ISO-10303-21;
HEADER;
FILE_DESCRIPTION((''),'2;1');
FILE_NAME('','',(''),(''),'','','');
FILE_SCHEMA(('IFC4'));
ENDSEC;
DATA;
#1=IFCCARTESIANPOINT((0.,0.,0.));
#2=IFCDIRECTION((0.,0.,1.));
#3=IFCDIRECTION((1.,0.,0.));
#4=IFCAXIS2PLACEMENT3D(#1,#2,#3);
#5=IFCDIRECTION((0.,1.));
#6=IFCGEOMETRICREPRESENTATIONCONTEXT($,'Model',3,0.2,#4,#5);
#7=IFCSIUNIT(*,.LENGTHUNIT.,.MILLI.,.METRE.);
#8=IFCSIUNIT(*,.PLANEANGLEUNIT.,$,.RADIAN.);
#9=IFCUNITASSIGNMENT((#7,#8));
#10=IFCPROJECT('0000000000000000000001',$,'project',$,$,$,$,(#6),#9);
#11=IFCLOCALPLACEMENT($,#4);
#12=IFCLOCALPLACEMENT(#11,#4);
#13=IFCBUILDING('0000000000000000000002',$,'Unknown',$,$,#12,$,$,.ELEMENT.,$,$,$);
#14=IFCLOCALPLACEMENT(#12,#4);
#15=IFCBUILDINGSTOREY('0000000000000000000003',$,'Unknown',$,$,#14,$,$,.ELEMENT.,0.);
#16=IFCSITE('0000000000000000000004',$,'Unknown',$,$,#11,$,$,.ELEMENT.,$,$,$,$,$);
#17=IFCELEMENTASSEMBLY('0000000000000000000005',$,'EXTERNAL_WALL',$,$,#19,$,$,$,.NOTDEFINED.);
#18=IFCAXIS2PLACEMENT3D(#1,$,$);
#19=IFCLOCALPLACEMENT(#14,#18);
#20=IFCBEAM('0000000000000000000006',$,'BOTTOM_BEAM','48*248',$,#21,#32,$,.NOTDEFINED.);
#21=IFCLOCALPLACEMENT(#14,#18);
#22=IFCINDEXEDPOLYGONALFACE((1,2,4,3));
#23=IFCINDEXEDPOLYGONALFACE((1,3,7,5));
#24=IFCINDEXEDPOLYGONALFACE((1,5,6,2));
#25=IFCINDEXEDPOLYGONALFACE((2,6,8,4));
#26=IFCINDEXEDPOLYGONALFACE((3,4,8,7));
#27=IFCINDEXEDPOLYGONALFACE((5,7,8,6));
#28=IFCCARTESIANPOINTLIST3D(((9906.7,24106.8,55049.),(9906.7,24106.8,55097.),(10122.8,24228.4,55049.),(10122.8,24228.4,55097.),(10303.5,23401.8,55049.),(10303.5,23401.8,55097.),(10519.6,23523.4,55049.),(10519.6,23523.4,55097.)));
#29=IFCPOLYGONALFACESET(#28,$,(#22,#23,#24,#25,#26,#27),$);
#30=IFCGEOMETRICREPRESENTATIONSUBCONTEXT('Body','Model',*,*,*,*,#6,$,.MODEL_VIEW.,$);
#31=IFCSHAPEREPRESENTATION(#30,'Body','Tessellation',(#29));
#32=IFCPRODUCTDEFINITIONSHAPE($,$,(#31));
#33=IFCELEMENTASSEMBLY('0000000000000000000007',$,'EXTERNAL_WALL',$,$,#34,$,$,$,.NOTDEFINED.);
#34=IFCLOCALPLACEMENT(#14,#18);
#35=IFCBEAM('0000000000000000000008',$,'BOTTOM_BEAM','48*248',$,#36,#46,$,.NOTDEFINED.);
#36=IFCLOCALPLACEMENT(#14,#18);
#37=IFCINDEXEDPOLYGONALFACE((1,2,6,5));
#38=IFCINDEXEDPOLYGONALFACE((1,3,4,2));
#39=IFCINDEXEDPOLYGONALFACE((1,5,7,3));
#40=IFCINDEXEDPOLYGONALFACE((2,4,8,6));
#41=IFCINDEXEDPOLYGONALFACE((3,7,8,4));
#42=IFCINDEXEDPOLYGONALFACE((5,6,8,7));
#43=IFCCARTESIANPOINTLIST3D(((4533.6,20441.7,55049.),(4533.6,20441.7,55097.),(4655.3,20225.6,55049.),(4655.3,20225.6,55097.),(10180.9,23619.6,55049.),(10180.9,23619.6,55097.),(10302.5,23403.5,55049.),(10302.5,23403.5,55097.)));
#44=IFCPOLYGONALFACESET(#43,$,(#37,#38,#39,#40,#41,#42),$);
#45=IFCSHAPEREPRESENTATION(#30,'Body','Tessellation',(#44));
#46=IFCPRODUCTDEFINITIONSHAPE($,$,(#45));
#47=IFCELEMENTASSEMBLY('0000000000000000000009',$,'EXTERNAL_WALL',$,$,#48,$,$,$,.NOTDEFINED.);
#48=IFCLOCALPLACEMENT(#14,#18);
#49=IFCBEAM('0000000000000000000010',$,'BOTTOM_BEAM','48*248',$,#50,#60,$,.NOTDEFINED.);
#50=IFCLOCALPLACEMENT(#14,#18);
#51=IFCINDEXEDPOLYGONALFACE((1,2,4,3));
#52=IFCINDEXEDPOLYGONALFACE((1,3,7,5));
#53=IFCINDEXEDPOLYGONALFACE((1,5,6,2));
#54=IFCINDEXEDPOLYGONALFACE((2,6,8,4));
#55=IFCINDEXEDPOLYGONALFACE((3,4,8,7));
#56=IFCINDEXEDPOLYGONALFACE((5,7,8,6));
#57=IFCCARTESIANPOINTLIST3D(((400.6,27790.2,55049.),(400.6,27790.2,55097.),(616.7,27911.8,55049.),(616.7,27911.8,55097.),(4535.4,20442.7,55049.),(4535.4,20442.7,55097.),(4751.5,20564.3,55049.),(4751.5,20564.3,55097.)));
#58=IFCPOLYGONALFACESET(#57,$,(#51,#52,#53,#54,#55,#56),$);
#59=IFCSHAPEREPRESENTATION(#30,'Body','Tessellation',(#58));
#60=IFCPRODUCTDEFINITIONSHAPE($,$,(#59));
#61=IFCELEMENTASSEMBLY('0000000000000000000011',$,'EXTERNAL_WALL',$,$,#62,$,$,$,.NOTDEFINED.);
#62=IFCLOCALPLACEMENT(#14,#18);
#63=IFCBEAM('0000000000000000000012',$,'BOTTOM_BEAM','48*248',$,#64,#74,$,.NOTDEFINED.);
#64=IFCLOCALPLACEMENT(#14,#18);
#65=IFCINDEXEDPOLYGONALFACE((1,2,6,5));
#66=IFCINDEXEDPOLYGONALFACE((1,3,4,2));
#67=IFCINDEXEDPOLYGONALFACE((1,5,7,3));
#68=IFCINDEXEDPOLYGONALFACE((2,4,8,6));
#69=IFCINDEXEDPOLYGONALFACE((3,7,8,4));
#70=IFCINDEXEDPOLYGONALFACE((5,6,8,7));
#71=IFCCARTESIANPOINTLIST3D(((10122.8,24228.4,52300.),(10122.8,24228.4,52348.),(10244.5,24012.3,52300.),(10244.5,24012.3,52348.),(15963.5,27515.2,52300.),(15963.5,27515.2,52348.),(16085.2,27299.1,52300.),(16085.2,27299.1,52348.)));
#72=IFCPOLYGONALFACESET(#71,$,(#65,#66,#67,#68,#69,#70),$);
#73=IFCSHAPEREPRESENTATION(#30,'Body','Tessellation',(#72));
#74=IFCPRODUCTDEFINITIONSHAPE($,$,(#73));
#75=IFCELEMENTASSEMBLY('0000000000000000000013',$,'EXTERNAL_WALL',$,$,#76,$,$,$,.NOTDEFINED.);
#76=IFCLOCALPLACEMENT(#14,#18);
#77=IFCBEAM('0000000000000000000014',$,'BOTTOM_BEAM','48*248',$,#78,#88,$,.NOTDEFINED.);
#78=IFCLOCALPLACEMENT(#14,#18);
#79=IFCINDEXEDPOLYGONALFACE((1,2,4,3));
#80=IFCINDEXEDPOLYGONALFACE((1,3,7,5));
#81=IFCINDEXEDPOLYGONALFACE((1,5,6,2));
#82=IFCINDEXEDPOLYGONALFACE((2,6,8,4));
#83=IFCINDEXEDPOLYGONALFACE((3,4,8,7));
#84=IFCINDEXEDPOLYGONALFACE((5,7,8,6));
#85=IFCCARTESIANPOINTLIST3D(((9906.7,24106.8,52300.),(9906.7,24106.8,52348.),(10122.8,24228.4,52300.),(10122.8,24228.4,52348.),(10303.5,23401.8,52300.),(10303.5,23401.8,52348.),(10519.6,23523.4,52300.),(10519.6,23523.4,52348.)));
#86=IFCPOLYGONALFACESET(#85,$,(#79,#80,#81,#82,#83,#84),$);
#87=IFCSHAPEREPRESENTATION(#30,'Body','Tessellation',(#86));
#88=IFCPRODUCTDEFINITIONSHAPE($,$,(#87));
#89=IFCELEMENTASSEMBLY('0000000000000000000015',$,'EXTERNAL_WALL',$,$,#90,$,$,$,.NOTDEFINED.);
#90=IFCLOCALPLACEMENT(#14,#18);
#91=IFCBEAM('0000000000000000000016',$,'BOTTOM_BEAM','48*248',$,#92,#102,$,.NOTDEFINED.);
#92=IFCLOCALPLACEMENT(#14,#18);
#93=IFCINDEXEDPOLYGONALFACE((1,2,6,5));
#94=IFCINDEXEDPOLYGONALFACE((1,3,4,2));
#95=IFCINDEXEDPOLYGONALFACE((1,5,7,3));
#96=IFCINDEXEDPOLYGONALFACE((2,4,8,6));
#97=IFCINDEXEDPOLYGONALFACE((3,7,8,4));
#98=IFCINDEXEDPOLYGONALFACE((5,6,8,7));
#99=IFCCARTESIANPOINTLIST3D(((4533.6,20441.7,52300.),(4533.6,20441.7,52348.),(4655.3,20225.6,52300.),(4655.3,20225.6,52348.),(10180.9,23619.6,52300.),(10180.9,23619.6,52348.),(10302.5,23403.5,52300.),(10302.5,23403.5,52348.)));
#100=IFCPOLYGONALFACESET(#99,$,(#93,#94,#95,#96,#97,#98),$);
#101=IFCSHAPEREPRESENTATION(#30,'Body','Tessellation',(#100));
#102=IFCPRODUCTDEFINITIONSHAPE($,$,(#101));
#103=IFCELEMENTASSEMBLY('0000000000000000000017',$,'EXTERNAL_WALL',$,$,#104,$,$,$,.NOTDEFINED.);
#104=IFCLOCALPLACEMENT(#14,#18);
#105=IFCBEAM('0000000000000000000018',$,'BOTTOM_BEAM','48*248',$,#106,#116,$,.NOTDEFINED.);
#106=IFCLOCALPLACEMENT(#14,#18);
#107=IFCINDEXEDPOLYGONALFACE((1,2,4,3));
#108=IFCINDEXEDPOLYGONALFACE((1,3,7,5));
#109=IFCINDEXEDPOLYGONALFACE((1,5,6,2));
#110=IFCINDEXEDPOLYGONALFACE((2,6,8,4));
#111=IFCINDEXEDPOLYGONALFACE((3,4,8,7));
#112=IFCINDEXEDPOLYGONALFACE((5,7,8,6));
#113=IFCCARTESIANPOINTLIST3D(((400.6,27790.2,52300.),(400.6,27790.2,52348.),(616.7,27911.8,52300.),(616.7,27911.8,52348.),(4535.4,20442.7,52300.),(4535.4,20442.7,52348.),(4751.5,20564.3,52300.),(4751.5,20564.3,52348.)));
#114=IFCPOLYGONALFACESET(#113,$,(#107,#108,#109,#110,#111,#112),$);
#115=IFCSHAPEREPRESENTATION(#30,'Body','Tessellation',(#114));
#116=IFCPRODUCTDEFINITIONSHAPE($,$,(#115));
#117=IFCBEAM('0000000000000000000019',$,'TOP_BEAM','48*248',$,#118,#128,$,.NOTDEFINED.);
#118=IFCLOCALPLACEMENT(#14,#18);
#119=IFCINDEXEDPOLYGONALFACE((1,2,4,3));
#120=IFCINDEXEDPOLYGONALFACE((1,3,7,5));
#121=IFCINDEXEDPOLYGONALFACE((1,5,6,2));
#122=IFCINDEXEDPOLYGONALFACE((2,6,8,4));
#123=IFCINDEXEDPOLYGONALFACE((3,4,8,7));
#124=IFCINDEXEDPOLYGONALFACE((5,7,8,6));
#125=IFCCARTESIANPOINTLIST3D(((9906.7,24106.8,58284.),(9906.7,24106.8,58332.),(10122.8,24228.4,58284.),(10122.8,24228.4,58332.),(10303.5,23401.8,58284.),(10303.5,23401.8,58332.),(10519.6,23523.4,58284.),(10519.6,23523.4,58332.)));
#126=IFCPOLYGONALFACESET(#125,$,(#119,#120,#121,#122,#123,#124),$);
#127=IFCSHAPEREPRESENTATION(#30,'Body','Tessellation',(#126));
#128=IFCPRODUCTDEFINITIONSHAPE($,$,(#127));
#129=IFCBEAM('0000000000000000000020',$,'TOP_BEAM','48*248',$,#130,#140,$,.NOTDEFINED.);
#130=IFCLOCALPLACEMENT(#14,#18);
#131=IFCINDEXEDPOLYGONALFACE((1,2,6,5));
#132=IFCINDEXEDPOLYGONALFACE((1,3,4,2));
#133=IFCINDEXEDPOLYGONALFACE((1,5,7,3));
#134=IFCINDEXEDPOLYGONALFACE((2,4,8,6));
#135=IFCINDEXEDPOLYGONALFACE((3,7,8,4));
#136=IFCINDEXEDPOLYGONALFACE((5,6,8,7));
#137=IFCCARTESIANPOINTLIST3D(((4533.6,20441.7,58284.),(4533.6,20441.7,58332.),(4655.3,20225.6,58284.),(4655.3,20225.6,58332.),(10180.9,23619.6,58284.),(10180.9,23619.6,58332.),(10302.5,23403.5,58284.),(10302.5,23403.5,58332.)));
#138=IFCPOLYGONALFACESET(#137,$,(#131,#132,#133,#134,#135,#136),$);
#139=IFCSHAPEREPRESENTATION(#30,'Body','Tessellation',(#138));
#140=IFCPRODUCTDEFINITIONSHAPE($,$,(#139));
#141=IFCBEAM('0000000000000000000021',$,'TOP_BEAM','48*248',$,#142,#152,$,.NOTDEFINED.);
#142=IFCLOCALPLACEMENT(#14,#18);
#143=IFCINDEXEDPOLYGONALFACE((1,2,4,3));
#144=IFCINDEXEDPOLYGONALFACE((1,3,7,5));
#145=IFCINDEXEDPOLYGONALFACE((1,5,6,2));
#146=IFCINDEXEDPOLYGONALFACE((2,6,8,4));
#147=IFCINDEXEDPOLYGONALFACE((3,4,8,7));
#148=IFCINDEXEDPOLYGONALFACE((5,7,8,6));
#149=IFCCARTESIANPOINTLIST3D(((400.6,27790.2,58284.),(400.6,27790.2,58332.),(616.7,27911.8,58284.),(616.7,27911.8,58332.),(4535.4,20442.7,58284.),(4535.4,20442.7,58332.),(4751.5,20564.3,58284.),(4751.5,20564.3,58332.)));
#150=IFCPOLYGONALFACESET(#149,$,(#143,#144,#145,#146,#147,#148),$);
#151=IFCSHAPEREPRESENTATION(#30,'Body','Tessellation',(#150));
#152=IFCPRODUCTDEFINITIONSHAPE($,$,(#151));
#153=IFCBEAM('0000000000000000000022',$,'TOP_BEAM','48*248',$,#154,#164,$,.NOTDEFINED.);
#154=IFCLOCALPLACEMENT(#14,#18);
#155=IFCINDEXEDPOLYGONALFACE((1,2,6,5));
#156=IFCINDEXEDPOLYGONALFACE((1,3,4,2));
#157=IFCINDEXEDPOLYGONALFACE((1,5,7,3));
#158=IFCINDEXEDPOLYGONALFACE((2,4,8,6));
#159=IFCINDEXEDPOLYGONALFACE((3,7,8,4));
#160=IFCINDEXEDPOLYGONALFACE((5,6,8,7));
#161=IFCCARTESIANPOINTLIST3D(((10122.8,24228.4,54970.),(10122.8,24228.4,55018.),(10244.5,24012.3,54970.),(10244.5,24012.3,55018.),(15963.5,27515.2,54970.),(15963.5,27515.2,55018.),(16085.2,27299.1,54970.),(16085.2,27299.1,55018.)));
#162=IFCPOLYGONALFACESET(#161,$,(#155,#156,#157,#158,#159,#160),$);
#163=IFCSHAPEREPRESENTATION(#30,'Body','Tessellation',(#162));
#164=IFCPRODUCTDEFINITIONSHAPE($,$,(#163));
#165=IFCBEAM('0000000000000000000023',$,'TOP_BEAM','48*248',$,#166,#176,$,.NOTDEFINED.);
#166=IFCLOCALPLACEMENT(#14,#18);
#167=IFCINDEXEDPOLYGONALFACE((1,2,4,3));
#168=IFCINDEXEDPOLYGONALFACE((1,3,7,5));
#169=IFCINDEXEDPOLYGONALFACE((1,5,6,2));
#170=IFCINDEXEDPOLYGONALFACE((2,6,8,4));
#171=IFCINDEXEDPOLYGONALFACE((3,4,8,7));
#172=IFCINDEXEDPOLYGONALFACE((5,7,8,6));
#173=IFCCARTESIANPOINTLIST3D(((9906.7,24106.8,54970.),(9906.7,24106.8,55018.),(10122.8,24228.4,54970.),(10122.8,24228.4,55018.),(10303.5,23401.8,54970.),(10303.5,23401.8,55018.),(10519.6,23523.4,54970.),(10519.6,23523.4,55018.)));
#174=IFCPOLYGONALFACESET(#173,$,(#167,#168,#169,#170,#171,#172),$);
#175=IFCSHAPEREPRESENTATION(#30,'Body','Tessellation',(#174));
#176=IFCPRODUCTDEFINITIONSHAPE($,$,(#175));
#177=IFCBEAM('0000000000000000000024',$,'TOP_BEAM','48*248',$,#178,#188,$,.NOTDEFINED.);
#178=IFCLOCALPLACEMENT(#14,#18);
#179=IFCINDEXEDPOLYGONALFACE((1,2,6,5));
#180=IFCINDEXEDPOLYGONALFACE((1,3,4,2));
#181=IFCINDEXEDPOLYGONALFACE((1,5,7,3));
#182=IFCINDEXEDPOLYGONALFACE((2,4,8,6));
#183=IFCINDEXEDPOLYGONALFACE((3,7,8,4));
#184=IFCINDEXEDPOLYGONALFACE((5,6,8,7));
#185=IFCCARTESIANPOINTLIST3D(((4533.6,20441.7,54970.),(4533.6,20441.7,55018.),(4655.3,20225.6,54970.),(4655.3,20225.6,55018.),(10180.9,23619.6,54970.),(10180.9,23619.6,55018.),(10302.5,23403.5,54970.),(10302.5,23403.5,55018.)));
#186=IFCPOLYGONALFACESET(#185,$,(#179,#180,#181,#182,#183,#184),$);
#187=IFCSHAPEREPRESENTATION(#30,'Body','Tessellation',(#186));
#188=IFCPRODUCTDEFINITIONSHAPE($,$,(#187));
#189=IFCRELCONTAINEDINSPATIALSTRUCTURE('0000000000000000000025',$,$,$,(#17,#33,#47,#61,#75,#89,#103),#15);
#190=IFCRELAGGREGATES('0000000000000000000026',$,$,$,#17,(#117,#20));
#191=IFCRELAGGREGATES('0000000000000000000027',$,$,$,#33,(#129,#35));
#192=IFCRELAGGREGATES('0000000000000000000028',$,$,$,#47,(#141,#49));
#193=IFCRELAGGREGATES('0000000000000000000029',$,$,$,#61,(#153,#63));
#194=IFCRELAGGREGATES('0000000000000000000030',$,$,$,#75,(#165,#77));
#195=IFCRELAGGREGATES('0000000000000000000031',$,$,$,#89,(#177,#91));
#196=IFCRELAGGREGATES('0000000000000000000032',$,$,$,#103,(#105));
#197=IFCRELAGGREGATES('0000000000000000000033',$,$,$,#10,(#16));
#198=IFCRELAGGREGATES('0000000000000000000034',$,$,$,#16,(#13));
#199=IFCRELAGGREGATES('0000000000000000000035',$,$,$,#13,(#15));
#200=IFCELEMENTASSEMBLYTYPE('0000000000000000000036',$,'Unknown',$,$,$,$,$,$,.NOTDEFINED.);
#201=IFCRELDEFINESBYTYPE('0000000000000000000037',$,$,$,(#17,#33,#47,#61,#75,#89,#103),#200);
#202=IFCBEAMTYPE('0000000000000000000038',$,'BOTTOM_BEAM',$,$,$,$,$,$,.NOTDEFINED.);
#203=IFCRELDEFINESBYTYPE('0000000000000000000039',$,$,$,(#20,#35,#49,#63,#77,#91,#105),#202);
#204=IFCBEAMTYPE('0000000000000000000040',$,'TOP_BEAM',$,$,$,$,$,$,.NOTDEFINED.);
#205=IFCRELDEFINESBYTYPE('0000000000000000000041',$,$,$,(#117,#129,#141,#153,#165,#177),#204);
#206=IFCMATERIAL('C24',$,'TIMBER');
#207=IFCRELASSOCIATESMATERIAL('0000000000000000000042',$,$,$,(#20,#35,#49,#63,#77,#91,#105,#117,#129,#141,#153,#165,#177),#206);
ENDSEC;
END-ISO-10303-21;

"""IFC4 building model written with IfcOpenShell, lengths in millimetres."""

from ifc_helpers import new_model, si_unit, direction, frame, origin_with_axes, origin_2d_with_axis, place, context, subcontext, project, spatial, rectangle, extrude, material, material_profile, profile_set, profile_usage, type_object, element, aggregate, save


model = new_model("IFC4")

# Units and contexts
model_context = context("Model", 3, precision=0.2, world=origin_with_axes(), true_north=direction((0.0, 1.0)))
body_context = subcontext(model_context, "Body", "Model", "MODEL_VIEW")
ifc_project = project(units=[si_unit("LENGTHUNIT", "METRE", prefix="MILLI"), si_unit("PLANEANGLEUNIT", "RADIAN")], contexts=[model_context])

# Site, building, storey
site_placement = place(None, origin_with_axes())
site = spatial("IfcSite", under=ifc_project, at=site_placement, Name="Unknown", CompositionType="ELEMENT")
building_placement = place(site_placement, origin_with_axes())
building = spatial("IfcBuilding", under=site, at=building_placement, Name="Unknown", CompositionType="ELEMENT")
storey_placement = place(building_placement, origin_with_axes())
storey = spatial("IfcBuildingStorey", under=building, at=storey_placement, Name="Unknown", CompositionType="ELEMENT", Elevation=0.0)

# Shared definitions
element_assembly_type = type_object("IfcElementAssemblyType", Name="Unknown", PredefinedType="NOTDEFINED")

# Element assemblies, beams
ifc_material_1 = material(Name="C24", Category="TIMBER")
ifc_material_profile_1 = material_profile(ifc_material_1, rectangle(XDim=248.0, YDim=48.0, at=origin_2d_with_axis()), Name="48*248")
ifc_profile_set_1 = profile_set([ifc_material_profile_1])
ifc_profile_usage_1 = profile_usage(ifc_profile_set_1, cardinal=3)
beam_type_1 = type_object("IfcBeamType", Name="BOTTOM_BEAM")
assembly_1_placement = place(storey_placement, frame((10014.8, 24167.6, 58308.0), z_axis=(-0.871487, -0.490418, 0.0), x_axis=(0.490421, -0.871485, 0.0)))
assembly_1 = element("IfcElementAssembly", 1, at=assembly_1_placement, inside=storey, type_object=element_assembly_type, Name="EXTERNAL_WALL", PredefinedType="NOTDEFINED")
beam_1_placement = place(assembly_1_placement, frame((0.0, -3235.0, 0.0), z_axis=(0.0, 0.0, 1.0), x_axis=(1.0, 0.0, 0.0)))
beam_1 = element("IfcBeam", 2, at=beam_1_placement, type_object=beam_type_1, material=ifc_profile_usage_1, Name="BOTTOM_BEAM", Description="48*248", PredefinedType="NOTDEFINED", context=body_context, shape_type="SolidModel", body=[
    extrude(rectangle(XDim=248.0, YDim=48.0, at=origin_2d_with_axis()), frame((0.0, 0.0, 0.0), z_axis=(-1.0, 0.0, 0.0), x_axis=(0.0, 0.0, 1.0)), (0.0, 0.0, -1.0), 809.0),
])
assembly_2_placement = place(storey_placement, frame((10241.7, 23511.6, 58308.0), z_axis=(-0.490421, 0.871486, 0.0), x_axis=(-0.871487, -0.490418, 0.0)))
assembly_2 = element("IfcElementAssembly", 3, at=assembly_2_placement, inside=storey, type_object=element_assembly_type, Name="EXTERNAL_WALL", PredefinedType="NOTDEFINED")
beam_2_placement = place(assembly_2_placement, frame((0.0, -3235.0, 0.0), z_axis=(0.0, 0.0, 1.0), x_axis=(1.0, 0.0, 0.0)))
beam_2 = element("IfcBeam", 4, at=beam_2_placement, type_object=beam_type_1, material=ifc_profile_usage_1, Name="BOTTOM_BEAM", Description="48*248", PredefinedType="NOTDEFINED", context=body_context, shape_type="SolidModel", body=[
    extrude(rectangle(XDim=248.0, YDim=48.0, at=origin_2d_with_axis()), frame((0.0, 0.0, 0.0), z_axis=(-1.0, 0.0, 0.0), x_axis=(0.0, 0.0, 1.0)), (0.0, 0.0, -1.0), 6480.0),
])
assembly_3_placement = place(storey_placement, frame((4643.5, 20503.5, 58308.0), z_axis=(0.871484, 0.490423, 0.0), x_axis=(-0.490421, 0.871486, 0.0)))
assembly_3 = element("IfcElementAssembly", 5, at=assembly_3_placement, inside=storey, type_object=element_assembly_type, Name="EXTERNAL_WALL", PredefinedType="NOTDEFINED")
beam_3_placement = place(assembly_3_placement, frame((0.0, -3235.0, 0.0), z_axis=(0.0, 0.0, 1.0), x_axis=(1.0, 0.0, 0.0)))
beam_3 = element("IfcBeam", 6, at=beam_3_placement, type_object=beam_type_1, material=ifc_profile_usage_1, Name="BOTTOM_BEAM", Description="48*248", PredefinedType="NOTDEFINED", context=body_context, shape_type="SolidModel", body=[
    extrude(rectangle(XDim=248.0, YDim=48.0, at=origin_2d_with_axis()), frame((0.0, 0.0, 0.0), z_axis=(-1.0, 0.0, 0.0), x_axis=(0.0, 0.0, 1.0)), (0.0, 0.0, -1.0), 8431.0),
])
assembly_4_placement = place(storey_placement, frame((16024.4, 27407.2, 54994.0), z_axis=(-0.490421, 0.871486, 0.0), x_axis=(-0.871487, -0.490418, 0.0)))
assembly_4 = element("IfcElementAssembly", 7, at=assembly_4_placement, inside=storey, type_object=element_assembly_type, Name="EXTERNAL_WALL", PredefinedType="NOTDEFINED")
beam_4_placement = place(assembly_4_placement, frame((0.0, -2670.0, 0.0), z_axis=(0.0, 0.0, 1.0), x_axis=(1.0, 0.0, 0.0)))
beam_4 = element("IfcBeam", 8, at=beam_4_placement, type_object=beam_type_1, material=ifc_profile_usage_1, Name="BOTTOM_BEAM", Description="48*248", PredefinedType="NOTDEFINED", context=body_context, shape_type="SolidModel", body=[
    extrude(rectangle(XDim=248.0, YDim=48.0, at=origin_2d_with_axis()), frame((0.0, 0.0, 0.0), z_axis=(-1.0, 0.0, 0.0), x_axis=(0.0, 0.0, 1.0)), (0.0, 0.0, -1.0), 6702.0),
])
assembly_5_placement = place(storey_placement, frame((10014.8, 24167.6, 54994.0), z_axis=(-0.871487, -0.490418, 0.0), x_axis=(0.490421, -0.871485, 0.0)))
assembly_5 = element("IfcElementAssembly", 9, at=assembly_5_placement, inside=storey, type_object=element_assembly_type, Name="EXTERNAL_WALL", PredefinedType="NOTDEFINED")
beam_5_placement = place(assembly_5_placement, frame((0.0, -2670.0, 0.0), z_axis=(0.0, 0.0, 1.0), x_axis=(1.0, 0.0, 0.0)))
beam_5 = element("IfcBeam", 10, at=beam_5_placement, type_object=beam_type_1, material=ifc_profile_usage_1, Name="BOTTOM_BEAM", Description="48*248", PredefinedType="NOTDEFINED", context=body_context, shape_type="SolidModel", body=[
    extrude(rectangle(XDim=248.0, YDim=48.0, at=origin_2d_with_axis()), frame((0.0, 0.0, 0.0), z_axis=(-1.0, 0.0, 0.0), x_axis=(0.0, 0.0, 1.0)), (0.0, 0.0, -1.0), 809.0),
])
assembly_6_placement = place(storey_placement, frame((10241.7, 23511.6, 54994.0), z_axis=(-0.490421, 0.871486, 0.0), x_axis=(-0.871487, -0.490418, 0.0)))
assembly_6 = element("IfcElementAssembly", 11, at=assembly_6_placement, inside=storey, type_object=element_assembly_type, Name="EXTERNAL_WALL", PredefinedType="NOTDEFINED")
beam_6_placement = place(assembly_6_placement, frame((0.0, -2670.0, 0.0), z_axis=(0.0, 0.0, 1.0), x_axis=(1.0, 0.0, 0.0)))
beam_6 = element("IfcBeam", 12, at=beam_6_placement, type_object=beam_type_1, material=ifc_profile_usage_1, Name="BOTTOM_BEAM", Description="48*248", PredefinedType="NOTDEFINED", context=body_context, shape_type="SolidModel", body=[
    extrude(rectangle(XDim=248.0, YDim=48.0, at=origin_2d_with_axis()), frame((0.0, 0.0, 0.0), z_axis=(-1.0, 0.0, 0.0), x_axis=(0.0, 0.0, 1.0)), (0.0, 0.0, -1.0), 6480.0),
])
assembly_7_placement = place(storey_placement, frame((4643.5, 20503.5, 54994.0), z_axis=(0.871484, 0.490423, 0.0), x_axis=(-0.490421, 0.871486, 0.0)))
assembly_7 = element("IfcElementAssembly", 13, at=assembly_7_placement, inside=storey, type_object=element_assembly_type, Name="EXTERNAL_WALL", PredefinedType="NOTDEFINED")
beam_7_placement = place(assembly_7_placement, frame((0.0, -2670.0, 0.0), z_axis=(0.0, 0.0, 1.0), x_axis=(1.0, 0.0, 0.0)))
beam_7 = element("IfcBeam", 14, at=beam_7_placement, type_object=beam_type_1, material=ifc_profile_usage_1, Name="BOTTOM_BEAM", Description="48*248", PredefinedType="NOTDEFINED", context=body_context, shape_type="SolidModel", body=[
    extrude(rectangle(XDim=248.0, YDim=48.0, at=origin_2d_with_axis()), frame((0.0, 0.0, 0.0), z_axis=(-1.0, 0.0, 0.0), x_axis=(0.0, 0.0, 1.0)), (0.0, 0.0, -1.0), 8431.0),
])

# Beams
beam_type_2 = type_object("IfcBeamType", Name="TOP_BEAM")
beam_8_placement = place(assembly_1_placement, origin_with_axes())
beam_8 = element("IfcBeam", 15, at=beam_8_placement, type_object=beam_type_2, material=ifc_profile_usage_1, Name="TOP_BEAM", Description="48*248", PredefinedType="NOTDEFINED", context=body_context, shape_type="SolidModel", body=[
    extrude(rectangle(XDim=248.0, YDim=48.0, at=origin_2d_with_axis()), frame((0.0, 0.0, 0.0), z_axis=(-1.0, 0.0, 0.0), x_axis=(0.0, 0.0, 1.0)), (0.0, 0.0, -1.0), 809.0),
])
aggregate(assembly_1, [beam_8, beam_1])
beam_9_placement = place(assembly_2_placement, origin_with_axes())
beam_9 = element("IfcBeam", 16, at=beam_9_placement, type_object=beam_type_2, material=ifc_profile_usage_1, Name="TOP_BEAM", Description="48*248", PredefinedType="NOTDEFINED", context=body_context, shape_type="SolidModel", body=[
    extrude(rectangle(XDim=248.0, YDim=48.0, at=origin_2d_with_axis()), frame((0.0, 0.0, 0.0), z_axis=(-1.0, 0.0, 0.0), x_axis=(0.0, 0.0, 1.0)), (0.0, 0.0, -1.0), 6480.0),
])
aggregate(assembly_2, [beam_9, beam_2])
beam_10_placement = place(assembly_3_placement, origin_with_axes())
beam_10 = element("IfcBeam", 17, at=beam_10_placement, type_object=beam_type_2, material=ifc_profile_usage_1, Name="TOP_BEAM", Description="48*248", PredefinedType="NOTDEFINED", context=body_context, shape_type="SolidModel", body=[
    extrude(rectangle(XDim=248.0, YDim=48.0, at=origin_2d_with_axis()), frame((0.0, 0.0, 0.0), z_axis=(-1.0, 0.0, 0.0), x_axis=(0.0, 0.0, 1.0)), (0.0, 0.0, -1.0), 8431.0),
])
aggregate(assembly_3, [beam_10, beam_3])
beam_11_placement = place(assembly_4_placement, origin_with_axes())
beam_11 = element("IfcBeam", 18, at=beam_11_placement, type_object=beam_type_2, material=ifc_profile_usage_1, Name="TOP_BEAM", Description="48*248", PredefinedType="NOTDEFINED", context=body_context, shape_type="SolidModel", body=[
    extrude(rectangle(XDim=248.0, YDim=48.0, at=origin_2d_with_axis()), frame((0.0, 0.0, 0.0), z_axis=(-1.0, 0.0, 0.0), x_axis=(0.0, 0.0, 1.0)), (0.0, 0.0, -1.0), 6702.0),
])
aggregate(assembly_4, [beam_11, beam_4])
beam_12_placement = place(assembly_5_placement, origin_with_axes())
beam_12 = element("IfcBeam", 19, at=beam_12_placement, type_object=beam_type_2, material=ifc_profile_usage_1, Name="TOP_BEAM", Description="48*248", PredefinedType="NOTDEFINED", context=body_context, shape_type="SolidModel", body=[
    extrude(rectangle(XDim=248.0, YDim=48.0, at=origin_2d_with_axis()), frame((0.0, 0.0, 0.0), z_axis=(-1.0, 0.0, 0.0), x_axis=(0.0, 0.0, 1.0)), (0.0, 0.0, -1.0), 809.0),
])
aggregate(assembly_5, [beam_12, beam_5])
beam_13_placement = place(assembly_6_placement, origin_with_axes())
beam_13 = element("IfcBeam", 20, at=beam_13_placement, type_object=beam_type_2, material=ifc_profile_usage_1, Name="TOP_BEAM", Description="48*248", PredefinedType="NOTDEFINED", context=body_context, shape_type="SolidModel", body=[
    extrude(rectangle(XDim=248.0, YDim=48.0, at=origin_2d_with_axis()), frame((0.0, 0.0, 0.0), z_axis=(-1.0, 0.0, 0.0), x_axis=(0.0, 0.0, 1.0)), (0.0, 0.0, -1.0), 6480.0),
])
aggregate(assembly_6, [beam_13, beam_6])
aggregate(assembly_7, [beam_7])

save(model, "model.ifc")
